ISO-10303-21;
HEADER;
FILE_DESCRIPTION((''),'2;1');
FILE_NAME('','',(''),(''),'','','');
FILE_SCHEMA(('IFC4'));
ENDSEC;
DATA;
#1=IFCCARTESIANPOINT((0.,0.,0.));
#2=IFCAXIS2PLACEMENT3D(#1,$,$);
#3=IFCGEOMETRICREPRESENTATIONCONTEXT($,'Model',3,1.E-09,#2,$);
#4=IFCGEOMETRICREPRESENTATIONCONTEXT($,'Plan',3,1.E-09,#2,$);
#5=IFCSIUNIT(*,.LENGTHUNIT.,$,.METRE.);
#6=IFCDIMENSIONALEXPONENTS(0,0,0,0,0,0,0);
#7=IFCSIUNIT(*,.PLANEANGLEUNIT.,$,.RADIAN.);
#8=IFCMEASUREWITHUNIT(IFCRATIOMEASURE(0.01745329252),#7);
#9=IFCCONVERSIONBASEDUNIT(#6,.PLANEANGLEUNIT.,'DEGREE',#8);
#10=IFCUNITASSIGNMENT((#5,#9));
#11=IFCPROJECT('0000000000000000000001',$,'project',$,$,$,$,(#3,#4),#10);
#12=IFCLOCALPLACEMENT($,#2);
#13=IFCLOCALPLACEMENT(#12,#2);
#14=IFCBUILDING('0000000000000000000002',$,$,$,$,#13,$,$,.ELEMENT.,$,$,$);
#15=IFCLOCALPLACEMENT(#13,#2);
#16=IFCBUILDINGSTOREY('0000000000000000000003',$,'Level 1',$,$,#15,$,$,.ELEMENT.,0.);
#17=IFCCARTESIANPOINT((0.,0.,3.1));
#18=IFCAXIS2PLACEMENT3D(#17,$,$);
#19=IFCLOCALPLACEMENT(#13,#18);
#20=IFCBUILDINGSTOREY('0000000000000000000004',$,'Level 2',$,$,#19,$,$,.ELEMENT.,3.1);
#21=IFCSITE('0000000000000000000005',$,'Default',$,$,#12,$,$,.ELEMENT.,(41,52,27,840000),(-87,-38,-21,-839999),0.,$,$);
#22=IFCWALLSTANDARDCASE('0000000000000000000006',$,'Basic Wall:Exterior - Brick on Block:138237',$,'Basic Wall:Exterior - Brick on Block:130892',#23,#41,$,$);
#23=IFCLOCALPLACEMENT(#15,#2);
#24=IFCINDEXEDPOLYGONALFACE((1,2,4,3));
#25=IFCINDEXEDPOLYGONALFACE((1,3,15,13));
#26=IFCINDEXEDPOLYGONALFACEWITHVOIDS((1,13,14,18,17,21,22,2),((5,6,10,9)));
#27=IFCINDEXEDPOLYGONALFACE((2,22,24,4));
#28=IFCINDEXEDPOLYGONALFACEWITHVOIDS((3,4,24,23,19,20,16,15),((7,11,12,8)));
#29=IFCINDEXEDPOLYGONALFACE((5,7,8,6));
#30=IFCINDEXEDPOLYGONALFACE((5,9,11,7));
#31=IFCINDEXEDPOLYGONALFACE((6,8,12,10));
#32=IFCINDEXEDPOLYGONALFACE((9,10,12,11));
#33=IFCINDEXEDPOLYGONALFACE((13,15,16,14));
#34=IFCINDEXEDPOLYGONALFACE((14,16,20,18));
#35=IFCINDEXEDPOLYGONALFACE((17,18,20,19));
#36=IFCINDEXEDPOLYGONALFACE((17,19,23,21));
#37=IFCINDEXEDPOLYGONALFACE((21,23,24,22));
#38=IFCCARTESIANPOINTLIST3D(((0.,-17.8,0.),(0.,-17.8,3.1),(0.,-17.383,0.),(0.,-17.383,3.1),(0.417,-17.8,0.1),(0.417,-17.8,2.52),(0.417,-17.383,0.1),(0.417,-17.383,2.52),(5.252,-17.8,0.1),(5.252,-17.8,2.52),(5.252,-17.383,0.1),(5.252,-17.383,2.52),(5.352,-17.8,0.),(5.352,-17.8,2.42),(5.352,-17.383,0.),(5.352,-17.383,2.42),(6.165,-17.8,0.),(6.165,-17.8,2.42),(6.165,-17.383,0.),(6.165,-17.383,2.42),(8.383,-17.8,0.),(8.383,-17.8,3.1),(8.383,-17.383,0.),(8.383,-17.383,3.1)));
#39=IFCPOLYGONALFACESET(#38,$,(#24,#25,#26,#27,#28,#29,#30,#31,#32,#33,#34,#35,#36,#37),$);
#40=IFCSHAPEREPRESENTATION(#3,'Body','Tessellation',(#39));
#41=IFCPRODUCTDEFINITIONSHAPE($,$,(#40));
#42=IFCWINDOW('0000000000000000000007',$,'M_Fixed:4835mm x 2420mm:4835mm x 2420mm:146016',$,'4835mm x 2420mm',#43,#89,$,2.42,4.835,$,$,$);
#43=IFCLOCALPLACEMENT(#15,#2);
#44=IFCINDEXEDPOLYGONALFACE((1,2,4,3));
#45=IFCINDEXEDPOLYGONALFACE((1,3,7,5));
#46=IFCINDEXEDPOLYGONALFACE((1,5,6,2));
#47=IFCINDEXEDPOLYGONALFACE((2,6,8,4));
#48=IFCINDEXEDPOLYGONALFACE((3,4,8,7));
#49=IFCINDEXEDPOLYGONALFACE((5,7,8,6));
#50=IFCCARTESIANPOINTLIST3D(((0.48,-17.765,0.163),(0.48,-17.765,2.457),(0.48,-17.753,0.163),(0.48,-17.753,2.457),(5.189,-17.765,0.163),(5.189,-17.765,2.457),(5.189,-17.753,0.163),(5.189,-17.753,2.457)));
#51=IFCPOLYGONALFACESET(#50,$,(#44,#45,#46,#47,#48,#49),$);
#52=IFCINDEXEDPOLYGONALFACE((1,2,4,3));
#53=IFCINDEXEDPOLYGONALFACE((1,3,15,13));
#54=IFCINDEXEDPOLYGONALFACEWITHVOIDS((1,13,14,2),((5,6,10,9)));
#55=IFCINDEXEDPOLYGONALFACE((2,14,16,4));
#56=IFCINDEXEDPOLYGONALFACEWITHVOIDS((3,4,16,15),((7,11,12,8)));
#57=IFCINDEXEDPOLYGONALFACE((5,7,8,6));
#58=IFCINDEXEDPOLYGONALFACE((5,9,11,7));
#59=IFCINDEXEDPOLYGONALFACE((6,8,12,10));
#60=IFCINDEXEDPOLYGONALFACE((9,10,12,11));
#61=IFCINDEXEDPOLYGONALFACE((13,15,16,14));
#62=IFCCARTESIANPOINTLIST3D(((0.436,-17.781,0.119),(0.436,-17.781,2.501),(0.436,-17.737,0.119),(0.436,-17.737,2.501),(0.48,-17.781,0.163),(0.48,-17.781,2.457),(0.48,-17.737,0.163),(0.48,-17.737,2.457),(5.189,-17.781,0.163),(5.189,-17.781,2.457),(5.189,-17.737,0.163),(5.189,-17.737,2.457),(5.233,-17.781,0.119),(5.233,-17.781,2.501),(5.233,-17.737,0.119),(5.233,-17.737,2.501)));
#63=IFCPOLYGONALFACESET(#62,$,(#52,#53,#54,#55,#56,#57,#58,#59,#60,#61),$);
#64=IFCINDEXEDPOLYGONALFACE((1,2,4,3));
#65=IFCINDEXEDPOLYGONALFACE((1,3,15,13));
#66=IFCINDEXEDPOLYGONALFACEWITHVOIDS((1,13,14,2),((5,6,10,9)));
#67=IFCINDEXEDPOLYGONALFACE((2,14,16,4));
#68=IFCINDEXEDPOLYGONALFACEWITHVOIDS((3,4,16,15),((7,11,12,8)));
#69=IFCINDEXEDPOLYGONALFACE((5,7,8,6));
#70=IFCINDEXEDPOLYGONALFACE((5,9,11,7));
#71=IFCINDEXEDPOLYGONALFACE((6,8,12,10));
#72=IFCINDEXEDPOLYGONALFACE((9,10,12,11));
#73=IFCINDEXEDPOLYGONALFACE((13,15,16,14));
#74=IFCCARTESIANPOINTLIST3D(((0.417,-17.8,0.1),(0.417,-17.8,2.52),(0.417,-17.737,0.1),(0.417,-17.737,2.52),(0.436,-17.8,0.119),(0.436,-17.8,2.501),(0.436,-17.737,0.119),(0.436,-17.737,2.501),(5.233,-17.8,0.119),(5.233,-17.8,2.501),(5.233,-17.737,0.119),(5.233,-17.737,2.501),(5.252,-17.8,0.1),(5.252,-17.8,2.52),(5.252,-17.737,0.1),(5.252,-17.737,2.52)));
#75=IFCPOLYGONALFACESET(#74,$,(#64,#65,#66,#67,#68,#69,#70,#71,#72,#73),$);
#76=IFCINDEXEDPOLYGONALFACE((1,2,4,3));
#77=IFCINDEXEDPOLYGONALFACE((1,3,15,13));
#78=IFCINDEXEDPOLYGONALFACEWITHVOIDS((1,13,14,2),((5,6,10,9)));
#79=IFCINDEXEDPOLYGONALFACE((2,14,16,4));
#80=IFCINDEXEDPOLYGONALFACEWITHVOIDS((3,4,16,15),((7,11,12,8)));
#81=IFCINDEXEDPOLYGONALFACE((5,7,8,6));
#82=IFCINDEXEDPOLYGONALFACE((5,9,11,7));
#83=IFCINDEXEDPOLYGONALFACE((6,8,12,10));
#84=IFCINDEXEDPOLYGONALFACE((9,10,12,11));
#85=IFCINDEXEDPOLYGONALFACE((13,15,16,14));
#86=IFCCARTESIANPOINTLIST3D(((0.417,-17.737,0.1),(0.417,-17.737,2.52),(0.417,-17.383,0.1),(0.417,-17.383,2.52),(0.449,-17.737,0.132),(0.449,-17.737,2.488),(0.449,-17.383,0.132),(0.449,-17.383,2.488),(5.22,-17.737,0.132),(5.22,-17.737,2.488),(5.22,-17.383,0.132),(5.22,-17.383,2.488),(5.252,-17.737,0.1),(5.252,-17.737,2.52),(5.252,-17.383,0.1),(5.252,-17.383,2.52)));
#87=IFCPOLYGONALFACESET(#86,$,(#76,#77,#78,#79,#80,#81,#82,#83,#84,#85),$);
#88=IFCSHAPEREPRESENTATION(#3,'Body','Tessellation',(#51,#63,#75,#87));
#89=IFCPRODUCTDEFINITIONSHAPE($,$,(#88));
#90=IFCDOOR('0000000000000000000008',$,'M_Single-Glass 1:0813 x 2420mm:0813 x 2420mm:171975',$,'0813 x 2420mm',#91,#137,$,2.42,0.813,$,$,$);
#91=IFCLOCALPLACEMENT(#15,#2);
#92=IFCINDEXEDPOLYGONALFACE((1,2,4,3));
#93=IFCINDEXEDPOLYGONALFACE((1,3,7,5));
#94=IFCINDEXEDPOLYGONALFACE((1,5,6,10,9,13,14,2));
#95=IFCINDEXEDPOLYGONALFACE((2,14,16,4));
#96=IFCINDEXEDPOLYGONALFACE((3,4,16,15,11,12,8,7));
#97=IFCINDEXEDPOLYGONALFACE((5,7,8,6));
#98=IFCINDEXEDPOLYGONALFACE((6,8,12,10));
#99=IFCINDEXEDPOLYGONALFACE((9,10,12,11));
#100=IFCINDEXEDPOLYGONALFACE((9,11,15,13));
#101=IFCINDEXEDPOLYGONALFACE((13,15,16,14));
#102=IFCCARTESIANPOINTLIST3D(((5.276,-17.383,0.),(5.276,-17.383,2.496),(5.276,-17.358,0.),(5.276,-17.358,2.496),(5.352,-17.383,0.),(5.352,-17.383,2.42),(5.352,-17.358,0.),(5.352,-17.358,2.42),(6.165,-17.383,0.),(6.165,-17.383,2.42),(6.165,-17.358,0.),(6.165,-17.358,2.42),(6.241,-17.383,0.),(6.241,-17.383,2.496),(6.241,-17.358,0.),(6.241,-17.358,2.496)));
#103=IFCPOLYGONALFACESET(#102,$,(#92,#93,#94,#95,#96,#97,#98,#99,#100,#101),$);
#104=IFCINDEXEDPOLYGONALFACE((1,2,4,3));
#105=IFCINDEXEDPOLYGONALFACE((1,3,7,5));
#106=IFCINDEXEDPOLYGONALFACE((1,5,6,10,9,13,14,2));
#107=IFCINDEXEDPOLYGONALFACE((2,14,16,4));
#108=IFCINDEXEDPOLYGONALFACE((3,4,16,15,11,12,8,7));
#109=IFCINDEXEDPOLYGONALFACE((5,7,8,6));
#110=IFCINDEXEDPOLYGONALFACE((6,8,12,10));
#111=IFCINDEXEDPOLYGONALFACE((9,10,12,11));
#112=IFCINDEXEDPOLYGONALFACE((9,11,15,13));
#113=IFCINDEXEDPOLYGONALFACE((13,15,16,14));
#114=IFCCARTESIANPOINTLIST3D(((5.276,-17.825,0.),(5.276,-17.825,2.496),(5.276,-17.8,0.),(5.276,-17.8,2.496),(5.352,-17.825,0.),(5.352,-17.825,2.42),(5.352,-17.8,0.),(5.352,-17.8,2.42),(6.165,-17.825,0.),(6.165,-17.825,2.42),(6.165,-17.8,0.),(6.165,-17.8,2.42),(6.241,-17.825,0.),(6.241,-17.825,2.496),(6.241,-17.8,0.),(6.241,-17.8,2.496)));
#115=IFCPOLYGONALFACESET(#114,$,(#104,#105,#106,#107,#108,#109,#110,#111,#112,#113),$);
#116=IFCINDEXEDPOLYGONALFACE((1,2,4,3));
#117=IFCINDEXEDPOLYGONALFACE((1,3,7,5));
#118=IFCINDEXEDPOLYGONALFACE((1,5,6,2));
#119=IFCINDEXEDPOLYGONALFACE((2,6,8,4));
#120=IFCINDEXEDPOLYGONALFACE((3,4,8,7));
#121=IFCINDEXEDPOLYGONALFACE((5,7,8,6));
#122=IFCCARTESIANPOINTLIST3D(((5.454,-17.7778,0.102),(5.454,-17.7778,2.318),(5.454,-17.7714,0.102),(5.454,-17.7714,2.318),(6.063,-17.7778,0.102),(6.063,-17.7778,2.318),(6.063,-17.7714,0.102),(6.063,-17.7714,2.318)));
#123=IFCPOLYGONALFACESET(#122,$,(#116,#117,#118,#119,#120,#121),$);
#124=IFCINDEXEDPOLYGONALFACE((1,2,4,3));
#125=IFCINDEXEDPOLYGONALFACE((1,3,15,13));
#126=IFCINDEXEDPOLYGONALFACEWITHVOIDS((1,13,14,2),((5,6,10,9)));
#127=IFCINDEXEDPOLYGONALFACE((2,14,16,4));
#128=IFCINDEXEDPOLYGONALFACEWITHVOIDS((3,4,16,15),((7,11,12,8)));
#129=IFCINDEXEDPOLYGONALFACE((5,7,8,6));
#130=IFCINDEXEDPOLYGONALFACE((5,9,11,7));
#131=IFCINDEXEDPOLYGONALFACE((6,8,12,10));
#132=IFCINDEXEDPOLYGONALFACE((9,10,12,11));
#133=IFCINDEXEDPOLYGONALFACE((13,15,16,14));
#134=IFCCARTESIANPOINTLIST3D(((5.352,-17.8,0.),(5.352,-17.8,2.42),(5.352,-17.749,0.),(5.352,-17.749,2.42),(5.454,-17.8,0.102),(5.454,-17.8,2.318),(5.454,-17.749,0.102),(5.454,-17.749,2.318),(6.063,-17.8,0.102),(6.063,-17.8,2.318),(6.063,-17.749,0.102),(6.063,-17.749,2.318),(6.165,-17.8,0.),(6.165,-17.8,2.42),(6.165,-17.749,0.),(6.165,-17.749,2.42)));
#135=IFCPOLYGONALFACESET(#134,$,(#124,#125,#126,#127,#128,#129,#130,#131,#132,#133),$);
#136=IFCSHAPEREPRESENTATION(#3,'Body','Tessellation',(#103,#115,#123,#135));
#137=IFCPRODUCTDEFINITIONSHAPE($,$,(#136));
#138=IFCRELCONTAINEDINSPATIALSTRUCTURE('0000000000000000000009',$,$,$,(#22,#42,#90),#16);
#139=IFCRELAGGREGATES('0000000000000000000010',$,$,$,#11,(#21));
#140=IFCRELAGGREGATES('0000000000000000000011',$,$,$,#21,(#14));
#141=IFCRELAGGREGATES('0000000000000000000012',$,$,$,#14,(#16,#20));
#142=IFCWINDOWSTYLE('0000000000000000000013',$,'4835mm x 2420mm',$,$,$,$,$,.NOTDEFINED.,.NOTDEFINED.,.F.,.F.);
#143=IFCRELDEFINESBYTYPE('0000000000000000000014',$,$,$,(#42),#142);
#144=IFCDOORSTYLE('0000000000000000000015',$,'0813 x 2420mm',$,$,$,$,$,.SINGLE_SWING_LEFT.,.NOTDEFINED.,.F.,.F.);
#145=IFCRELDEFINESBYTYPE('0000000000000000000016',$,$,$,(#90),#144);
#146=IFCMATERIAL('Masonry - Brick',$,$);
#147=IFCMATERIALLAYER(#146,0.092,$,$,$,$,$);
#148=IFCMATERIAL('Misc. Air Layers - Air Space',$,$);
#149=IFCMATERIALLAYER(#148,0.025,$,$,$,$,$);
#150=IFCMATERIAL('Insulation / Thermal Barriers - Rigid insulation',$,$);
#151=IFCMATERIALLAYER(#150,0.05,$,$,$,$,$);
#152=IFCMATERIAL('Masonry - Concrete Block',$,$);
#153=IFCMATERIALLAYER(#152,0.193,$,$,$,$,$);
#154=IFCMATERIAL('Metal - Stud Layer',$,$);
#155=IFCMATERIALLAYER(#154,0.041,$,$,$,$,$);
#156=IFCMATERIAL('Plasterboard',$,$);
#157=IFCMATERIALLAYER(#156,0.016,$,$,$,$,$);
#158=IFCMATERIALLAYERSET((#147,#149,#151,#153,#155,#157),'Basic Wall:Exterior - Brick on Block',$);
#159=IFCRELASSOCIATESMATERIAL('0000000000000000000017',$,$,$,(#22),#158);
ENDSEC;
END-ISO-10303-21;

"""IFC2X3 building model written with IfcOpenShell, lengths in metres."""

from ifc_helpers import new_model, entity, si_unit, converted_unit, frame, frame_2d, origin, origin_2d_with_axis, place, context, project, spatial, polyline, rectangle, outline, extrude, source, transform, mapped, material, layer, layer_set, layer_usage, type_object, type_shapes, element, fill, save


model = new_model("IFC2X3")

# Units and contexts
model_context = context("Model", 3, precision=1e-09, world=origin())
plan_context = context("Plan", 3, precision=1e-09, world=origin())
ifc_project = project(units=[si_unit("LENGTHUNIT", "METRE"), converted_unit("PLANEANGLEUNIT", "DEGREE", entity("IfcRatioMeasure", 0.01745329252), si_unit("PLANEANGLEUNIT", "RADIAN"), dimensions=[0, 0, 0, 0, 0, 0, 0])], contexts=[model_context, plan_context])

# Site, building, storey
site_placement = place(None, origin())
site = spatial("IfcSite", under=ifc_project, at=site_placement, Name="Default", CompositionType="ELEMENT", RefLatitude=(41, 52, 27, 840000), RefLongitude=(-87, -38, -21, -839999), RefElevation=0.0)
building_placement = place(site_placement, origin())
building = spatial("IfcBuilding", under=site, at=building_placement, CompositionType="ELEMENT")
storey_1_placement = place(building_placement, origin())
storey_1 = spatial("IfcBuildingStorey", under=building, at=storey_1_placement, Name="Level 1", CompositionType="ELEMENT", Elevation=0.0)

# Wall, openings, window, door
ifc_material_1 = material(Name="Masonry - Brick")
ifc_layer_1 = layer(ifc_material_1, 0.092)
ifc_material_2 = material(Name="Misc. Air Layers - Air Space")
ifc_layer_2 = layer(ifc_material_2, 0.025)
ifc_material_3 = material(Name="Insulation / Thermal Barriers - Rigid insulation")
ifc_layer_3 = layer(ifc_material_3, 0.05)
ifc_material_4 = material(Name="Masonry - Concrete Block")
ifc_layer_4 = layer(ifc_material_4, 0.193)
ifc_material_5 = material(Name="Metal - Stud Layer")
ifc_layer_5 = layer(ifc_material_5, 0.041)
ifc_material_6 = material(Name="Plasterboard")
ifc_layer_6 = layer(ifc_material_6, 0.016)
ifc_layer_set_1 = layer_set([ifc_layer_1, ifc_layer_2, ifc_layer_3, ifc_layer_4, ifc_layer_5, ifc_layer_6], Name="Basic Wall:Exterior - Brick on Block")
ifc_layer_usage_1 = layer_usage(ifc_layer_set_1, "AXIS2", "NEGATIVE", 0.2085)
wall_1_placement = place(storey_1_placement, frame((8.383, -17.5915, 0.0), z_axis=(0.0, 0.0, 1.0), x_axis=(-1.0, 0.0, 0.0)))
wall_1 = element("IfcWallStandardCase", 1, at=wall_1_placement, inside=storey_1, material=ifc_layer_usage_1, Name="Basic Wall:Exterior - Brick on Block:138237", ObjectType="Basic Wall:Exterior - Brick on Block:130892", context=model_context, shape_type="SweptSolid", body=[
    extrude(rectangle(XDim=8.383, YDim=0.417, at=frame_2d((4.1915, 0.0), x_axis=(-1.0, 0.0))), origin(), (0.0, 0.0, 1.0), 3.1),
])
opening_1_placement = place(wall_1_placement, frame((3.131, -0.2085, 0.1)))
opening_1 = element("IfcOpeningElement", 2, at=opening_1_placement, cuts=wall_1, ObjectType="Opening", context=model_context, shape_type="SweptSolid", body=[
    extrude(rectangle(XDim=2.42, YDim=4.835, at=frame_2d((1.21, 2.4175), x_axis=(1.0, 0.0))), frame((0.0, 0.0, 0.0), z_axis=(0.0, 1.0, 0.0), x_axis=(0.0, 0.0, 1.0)), (0.0, 0.0, 1.0), 0.417),
])
opening_2_placement = place(wall_1_placement, frame((2.218, -0.2085, 0.0)))
opening_2 = element("IfcOpeningElement", 3, at=opening_2_placement, cuts=wall_1, ObjectType="Opening", context=model_context, shape_type="SweptSolid", body=[
    extrude(rectangle(XDim=0.813, YDim=2.42, at=frame_2d((1.21, 0.4065), x_axis=(0.0, -1.0))), frame((0.0, 0.0, 0.0), z_axis=(0.0, 1.0, 0.0), x_axis=(0.0, 0.0, 1.0)), (0.0, 0.0, 1.0), 0.417),
])
window_style_1 = type_object("IfcWindowStyle", Name="4835mm x 2420mm", ConstructionType="NOTDEFINED", OperationType="NOTDEFINED", ParameterTakesPrecedence=False, Sizeable=False)
shared_shape_1 = source(origin(), model_context, "Body", "SweptSolid", [
    extrude(rectangle(XDim=0.012, YDim=4.709, at=origin_2d_with_axis()), frame((2.4175, 0.376, 0.063), z_axis=(0.0, 0.0, 1.0), x_axis=(0.0, -1.0, 0.0)), (0.0, 0.0, 1.0), 2.294),
    extrude(outline(polyline([(-2.3985, -1.191), (2.3985, -1.191), (2.3985, 1.191), (-2.3985, 1.191), (-2.3985, -1.191)]), holes=[polyline([(-2.3545, -1.147), (-2.3545, 1.147), (2.3545, 1.147), (2.3545, -1.147), (-2.3545, -1.147)])]), frame((2.4175, 0.354, 1.21), z_axis=(0.0, 1.0, 0.0), x_axis=(1.0, 0.0, 0.0)), (0.0, 0.0, 1.0), 0.044),
    extrude(outline(polyline([(-2.4175, -1.21), (2.4175, -1.21), (2.4175, 1.21), (-2.4175, 1.21), (-2.4175, -1.21)]), holes=[polyline([(-2.3985, -1.191), (-2.3985, 1.191), (2.3985, 1.191), (2.3985, -1.191), (-2.3985, -1.191)])]), frame((2.4175, 0.354, 1.21), z_axis=(0.0, 1.0, 0.0), x_axis=(1.0, 0.0, 0.0)), (0.0, 0.0, 1.0), 0.063),
    extrude(outline(polyline([(-2.4175, -1.21), (2.4175, -1.21), (2.4175, 1.21), (-2.4175, 1.21), (-2.4175, -1.21)]), holes=[polyline([(-2.3855, -1.178), (-2.3855, 1.178), (2.3855, 1.178), (2.3855, -1.178), (-2.3855, -1.178)])]), frame((2.4175, 0.0, 1.21), z_axis=(0.0, 1.0, 0.0), x_axis=(1.0, 0.0, 0.0)), (0.0, 0.0, 1.0), 0.354),
])
type_shapes(window_style_1, [shared_shape_1])
window_1_placement = place(opening_1_placement, origin())
window_1 = element("IfcWindow", 4, at=window_1_placement, inside=storey_1, type_object=window_style_1, Name="M_Fixed:4835mm x 2420mm:4835mm x 2420mm:146016", ObjectType="4835mm x 2420mm", OverallHeight=2.42, OverallWidth=4.835, context=model_context, shape_type="MappedRepresentation", body=[
    mapped(shared_shape_1, transform((0.0, 0.0, 0.0), scale=1.0)),
])
fill(opening_1, window_1)
door_style_1 = type_object("IfcDoorStyle", Name="0813 x 2420mm", ConstructionType="NOTDEFINED", OperationType="SINGLE_SWING_LEFT", ParameterTakesPrecedence=False, Sizeable=False)
shared_shape_2 = source(origin(), model_context, "Body", "SweptSolid", [
    extrude(outline(polyline([(-0.4065, -1.191), (-0.4065, 1.229), (-0.4825, 1.229), (-0.4825, -1.267), (0.4825, -1.267), (0.4825, 1.229), (0.4065, 1.229), (0.4065, -1.191), (-0.4065, -1.191)])), frame((0.4065, 0.0, 1.229), z_axis=(0.0, 1.0, 0.0), x_axis=(1.0, 0.0, 0.0)), (0.0, 0.0, -1.0), 0.025),
    extrude(outline(polyline([(-0.4065, -1.191), (-0.4065, 1.229), (-0.4825, 1.229), (-0.4825, -1.267), (0.4825, -1.267), (0.4825, 1.229), (0.4065, 1.229), (0.4065, -1.191), (-0.4065, -1.191)])), frame((0.4065, 0.442, 1.229), z_axis=(0.0, 1.0, 0.0), x_axis=(1.0, 0.0, 0.0)), (0.0, 0.0, -1.0), 0.025),
    extrude(rectangle(XDim=0.609, YDim=0.0063, at=origin_2d_with_axis()), frame((0.4065, 0.3916, 0.102)), (0.0, 0.0, 1.0), 2.216),
    extrude(outline(polyline([(-1.21, -0.4065), (1.21, -0.4065), (1.21, 0.4065), (-1.21, 0.4065), (-1.21, -0.4065)]), holes=[polyline([(-1.108, 0.3045), (1.108, 0.3045), (1.108, -0.3045), (-1.108, -0.3045), (-1.108, 0.3045)])]), frame((0.4065, 0.417, 1.21), z_axis=(0.0, -1.0, 0.0), x_axis=(0.0, 0.0, -1.0)), (0.0, 0.0, 1.0), 0.051),
])
type_shapes(door_style_1, [shared_shape_2])
door_1_placement = place(opening_2_placement, origin())
door_1 = element("IfcDoor", 5, at=door_1_placement, inside=storey_1, type_object=door_style_1, Name="M_Single-Glass 1:0813 x 2420mm:0813 x 2420mm:171975", ObjectType="0813 x 2420mm", OverallHeight=2.42, OverallWidth=0.813, context=model_context, shape_type="MappedRepresentation", body=[
    mapped(shared_shape_2, transform((0.0, 0.0, 0.0), scale=1.0)),
])
fill(opening_2, door_1)

# Shared definitions
storey_2_placement = place(building_placement, frame((0.0, 0.0, 3.1)))
storey_2 = spatial("IfcBuildingStorey", under=building, at=storey_2_placement, Name="Level 2", CompositionType="ELEMENT", Elevation=3.1)

save(model, "model.ifc")
